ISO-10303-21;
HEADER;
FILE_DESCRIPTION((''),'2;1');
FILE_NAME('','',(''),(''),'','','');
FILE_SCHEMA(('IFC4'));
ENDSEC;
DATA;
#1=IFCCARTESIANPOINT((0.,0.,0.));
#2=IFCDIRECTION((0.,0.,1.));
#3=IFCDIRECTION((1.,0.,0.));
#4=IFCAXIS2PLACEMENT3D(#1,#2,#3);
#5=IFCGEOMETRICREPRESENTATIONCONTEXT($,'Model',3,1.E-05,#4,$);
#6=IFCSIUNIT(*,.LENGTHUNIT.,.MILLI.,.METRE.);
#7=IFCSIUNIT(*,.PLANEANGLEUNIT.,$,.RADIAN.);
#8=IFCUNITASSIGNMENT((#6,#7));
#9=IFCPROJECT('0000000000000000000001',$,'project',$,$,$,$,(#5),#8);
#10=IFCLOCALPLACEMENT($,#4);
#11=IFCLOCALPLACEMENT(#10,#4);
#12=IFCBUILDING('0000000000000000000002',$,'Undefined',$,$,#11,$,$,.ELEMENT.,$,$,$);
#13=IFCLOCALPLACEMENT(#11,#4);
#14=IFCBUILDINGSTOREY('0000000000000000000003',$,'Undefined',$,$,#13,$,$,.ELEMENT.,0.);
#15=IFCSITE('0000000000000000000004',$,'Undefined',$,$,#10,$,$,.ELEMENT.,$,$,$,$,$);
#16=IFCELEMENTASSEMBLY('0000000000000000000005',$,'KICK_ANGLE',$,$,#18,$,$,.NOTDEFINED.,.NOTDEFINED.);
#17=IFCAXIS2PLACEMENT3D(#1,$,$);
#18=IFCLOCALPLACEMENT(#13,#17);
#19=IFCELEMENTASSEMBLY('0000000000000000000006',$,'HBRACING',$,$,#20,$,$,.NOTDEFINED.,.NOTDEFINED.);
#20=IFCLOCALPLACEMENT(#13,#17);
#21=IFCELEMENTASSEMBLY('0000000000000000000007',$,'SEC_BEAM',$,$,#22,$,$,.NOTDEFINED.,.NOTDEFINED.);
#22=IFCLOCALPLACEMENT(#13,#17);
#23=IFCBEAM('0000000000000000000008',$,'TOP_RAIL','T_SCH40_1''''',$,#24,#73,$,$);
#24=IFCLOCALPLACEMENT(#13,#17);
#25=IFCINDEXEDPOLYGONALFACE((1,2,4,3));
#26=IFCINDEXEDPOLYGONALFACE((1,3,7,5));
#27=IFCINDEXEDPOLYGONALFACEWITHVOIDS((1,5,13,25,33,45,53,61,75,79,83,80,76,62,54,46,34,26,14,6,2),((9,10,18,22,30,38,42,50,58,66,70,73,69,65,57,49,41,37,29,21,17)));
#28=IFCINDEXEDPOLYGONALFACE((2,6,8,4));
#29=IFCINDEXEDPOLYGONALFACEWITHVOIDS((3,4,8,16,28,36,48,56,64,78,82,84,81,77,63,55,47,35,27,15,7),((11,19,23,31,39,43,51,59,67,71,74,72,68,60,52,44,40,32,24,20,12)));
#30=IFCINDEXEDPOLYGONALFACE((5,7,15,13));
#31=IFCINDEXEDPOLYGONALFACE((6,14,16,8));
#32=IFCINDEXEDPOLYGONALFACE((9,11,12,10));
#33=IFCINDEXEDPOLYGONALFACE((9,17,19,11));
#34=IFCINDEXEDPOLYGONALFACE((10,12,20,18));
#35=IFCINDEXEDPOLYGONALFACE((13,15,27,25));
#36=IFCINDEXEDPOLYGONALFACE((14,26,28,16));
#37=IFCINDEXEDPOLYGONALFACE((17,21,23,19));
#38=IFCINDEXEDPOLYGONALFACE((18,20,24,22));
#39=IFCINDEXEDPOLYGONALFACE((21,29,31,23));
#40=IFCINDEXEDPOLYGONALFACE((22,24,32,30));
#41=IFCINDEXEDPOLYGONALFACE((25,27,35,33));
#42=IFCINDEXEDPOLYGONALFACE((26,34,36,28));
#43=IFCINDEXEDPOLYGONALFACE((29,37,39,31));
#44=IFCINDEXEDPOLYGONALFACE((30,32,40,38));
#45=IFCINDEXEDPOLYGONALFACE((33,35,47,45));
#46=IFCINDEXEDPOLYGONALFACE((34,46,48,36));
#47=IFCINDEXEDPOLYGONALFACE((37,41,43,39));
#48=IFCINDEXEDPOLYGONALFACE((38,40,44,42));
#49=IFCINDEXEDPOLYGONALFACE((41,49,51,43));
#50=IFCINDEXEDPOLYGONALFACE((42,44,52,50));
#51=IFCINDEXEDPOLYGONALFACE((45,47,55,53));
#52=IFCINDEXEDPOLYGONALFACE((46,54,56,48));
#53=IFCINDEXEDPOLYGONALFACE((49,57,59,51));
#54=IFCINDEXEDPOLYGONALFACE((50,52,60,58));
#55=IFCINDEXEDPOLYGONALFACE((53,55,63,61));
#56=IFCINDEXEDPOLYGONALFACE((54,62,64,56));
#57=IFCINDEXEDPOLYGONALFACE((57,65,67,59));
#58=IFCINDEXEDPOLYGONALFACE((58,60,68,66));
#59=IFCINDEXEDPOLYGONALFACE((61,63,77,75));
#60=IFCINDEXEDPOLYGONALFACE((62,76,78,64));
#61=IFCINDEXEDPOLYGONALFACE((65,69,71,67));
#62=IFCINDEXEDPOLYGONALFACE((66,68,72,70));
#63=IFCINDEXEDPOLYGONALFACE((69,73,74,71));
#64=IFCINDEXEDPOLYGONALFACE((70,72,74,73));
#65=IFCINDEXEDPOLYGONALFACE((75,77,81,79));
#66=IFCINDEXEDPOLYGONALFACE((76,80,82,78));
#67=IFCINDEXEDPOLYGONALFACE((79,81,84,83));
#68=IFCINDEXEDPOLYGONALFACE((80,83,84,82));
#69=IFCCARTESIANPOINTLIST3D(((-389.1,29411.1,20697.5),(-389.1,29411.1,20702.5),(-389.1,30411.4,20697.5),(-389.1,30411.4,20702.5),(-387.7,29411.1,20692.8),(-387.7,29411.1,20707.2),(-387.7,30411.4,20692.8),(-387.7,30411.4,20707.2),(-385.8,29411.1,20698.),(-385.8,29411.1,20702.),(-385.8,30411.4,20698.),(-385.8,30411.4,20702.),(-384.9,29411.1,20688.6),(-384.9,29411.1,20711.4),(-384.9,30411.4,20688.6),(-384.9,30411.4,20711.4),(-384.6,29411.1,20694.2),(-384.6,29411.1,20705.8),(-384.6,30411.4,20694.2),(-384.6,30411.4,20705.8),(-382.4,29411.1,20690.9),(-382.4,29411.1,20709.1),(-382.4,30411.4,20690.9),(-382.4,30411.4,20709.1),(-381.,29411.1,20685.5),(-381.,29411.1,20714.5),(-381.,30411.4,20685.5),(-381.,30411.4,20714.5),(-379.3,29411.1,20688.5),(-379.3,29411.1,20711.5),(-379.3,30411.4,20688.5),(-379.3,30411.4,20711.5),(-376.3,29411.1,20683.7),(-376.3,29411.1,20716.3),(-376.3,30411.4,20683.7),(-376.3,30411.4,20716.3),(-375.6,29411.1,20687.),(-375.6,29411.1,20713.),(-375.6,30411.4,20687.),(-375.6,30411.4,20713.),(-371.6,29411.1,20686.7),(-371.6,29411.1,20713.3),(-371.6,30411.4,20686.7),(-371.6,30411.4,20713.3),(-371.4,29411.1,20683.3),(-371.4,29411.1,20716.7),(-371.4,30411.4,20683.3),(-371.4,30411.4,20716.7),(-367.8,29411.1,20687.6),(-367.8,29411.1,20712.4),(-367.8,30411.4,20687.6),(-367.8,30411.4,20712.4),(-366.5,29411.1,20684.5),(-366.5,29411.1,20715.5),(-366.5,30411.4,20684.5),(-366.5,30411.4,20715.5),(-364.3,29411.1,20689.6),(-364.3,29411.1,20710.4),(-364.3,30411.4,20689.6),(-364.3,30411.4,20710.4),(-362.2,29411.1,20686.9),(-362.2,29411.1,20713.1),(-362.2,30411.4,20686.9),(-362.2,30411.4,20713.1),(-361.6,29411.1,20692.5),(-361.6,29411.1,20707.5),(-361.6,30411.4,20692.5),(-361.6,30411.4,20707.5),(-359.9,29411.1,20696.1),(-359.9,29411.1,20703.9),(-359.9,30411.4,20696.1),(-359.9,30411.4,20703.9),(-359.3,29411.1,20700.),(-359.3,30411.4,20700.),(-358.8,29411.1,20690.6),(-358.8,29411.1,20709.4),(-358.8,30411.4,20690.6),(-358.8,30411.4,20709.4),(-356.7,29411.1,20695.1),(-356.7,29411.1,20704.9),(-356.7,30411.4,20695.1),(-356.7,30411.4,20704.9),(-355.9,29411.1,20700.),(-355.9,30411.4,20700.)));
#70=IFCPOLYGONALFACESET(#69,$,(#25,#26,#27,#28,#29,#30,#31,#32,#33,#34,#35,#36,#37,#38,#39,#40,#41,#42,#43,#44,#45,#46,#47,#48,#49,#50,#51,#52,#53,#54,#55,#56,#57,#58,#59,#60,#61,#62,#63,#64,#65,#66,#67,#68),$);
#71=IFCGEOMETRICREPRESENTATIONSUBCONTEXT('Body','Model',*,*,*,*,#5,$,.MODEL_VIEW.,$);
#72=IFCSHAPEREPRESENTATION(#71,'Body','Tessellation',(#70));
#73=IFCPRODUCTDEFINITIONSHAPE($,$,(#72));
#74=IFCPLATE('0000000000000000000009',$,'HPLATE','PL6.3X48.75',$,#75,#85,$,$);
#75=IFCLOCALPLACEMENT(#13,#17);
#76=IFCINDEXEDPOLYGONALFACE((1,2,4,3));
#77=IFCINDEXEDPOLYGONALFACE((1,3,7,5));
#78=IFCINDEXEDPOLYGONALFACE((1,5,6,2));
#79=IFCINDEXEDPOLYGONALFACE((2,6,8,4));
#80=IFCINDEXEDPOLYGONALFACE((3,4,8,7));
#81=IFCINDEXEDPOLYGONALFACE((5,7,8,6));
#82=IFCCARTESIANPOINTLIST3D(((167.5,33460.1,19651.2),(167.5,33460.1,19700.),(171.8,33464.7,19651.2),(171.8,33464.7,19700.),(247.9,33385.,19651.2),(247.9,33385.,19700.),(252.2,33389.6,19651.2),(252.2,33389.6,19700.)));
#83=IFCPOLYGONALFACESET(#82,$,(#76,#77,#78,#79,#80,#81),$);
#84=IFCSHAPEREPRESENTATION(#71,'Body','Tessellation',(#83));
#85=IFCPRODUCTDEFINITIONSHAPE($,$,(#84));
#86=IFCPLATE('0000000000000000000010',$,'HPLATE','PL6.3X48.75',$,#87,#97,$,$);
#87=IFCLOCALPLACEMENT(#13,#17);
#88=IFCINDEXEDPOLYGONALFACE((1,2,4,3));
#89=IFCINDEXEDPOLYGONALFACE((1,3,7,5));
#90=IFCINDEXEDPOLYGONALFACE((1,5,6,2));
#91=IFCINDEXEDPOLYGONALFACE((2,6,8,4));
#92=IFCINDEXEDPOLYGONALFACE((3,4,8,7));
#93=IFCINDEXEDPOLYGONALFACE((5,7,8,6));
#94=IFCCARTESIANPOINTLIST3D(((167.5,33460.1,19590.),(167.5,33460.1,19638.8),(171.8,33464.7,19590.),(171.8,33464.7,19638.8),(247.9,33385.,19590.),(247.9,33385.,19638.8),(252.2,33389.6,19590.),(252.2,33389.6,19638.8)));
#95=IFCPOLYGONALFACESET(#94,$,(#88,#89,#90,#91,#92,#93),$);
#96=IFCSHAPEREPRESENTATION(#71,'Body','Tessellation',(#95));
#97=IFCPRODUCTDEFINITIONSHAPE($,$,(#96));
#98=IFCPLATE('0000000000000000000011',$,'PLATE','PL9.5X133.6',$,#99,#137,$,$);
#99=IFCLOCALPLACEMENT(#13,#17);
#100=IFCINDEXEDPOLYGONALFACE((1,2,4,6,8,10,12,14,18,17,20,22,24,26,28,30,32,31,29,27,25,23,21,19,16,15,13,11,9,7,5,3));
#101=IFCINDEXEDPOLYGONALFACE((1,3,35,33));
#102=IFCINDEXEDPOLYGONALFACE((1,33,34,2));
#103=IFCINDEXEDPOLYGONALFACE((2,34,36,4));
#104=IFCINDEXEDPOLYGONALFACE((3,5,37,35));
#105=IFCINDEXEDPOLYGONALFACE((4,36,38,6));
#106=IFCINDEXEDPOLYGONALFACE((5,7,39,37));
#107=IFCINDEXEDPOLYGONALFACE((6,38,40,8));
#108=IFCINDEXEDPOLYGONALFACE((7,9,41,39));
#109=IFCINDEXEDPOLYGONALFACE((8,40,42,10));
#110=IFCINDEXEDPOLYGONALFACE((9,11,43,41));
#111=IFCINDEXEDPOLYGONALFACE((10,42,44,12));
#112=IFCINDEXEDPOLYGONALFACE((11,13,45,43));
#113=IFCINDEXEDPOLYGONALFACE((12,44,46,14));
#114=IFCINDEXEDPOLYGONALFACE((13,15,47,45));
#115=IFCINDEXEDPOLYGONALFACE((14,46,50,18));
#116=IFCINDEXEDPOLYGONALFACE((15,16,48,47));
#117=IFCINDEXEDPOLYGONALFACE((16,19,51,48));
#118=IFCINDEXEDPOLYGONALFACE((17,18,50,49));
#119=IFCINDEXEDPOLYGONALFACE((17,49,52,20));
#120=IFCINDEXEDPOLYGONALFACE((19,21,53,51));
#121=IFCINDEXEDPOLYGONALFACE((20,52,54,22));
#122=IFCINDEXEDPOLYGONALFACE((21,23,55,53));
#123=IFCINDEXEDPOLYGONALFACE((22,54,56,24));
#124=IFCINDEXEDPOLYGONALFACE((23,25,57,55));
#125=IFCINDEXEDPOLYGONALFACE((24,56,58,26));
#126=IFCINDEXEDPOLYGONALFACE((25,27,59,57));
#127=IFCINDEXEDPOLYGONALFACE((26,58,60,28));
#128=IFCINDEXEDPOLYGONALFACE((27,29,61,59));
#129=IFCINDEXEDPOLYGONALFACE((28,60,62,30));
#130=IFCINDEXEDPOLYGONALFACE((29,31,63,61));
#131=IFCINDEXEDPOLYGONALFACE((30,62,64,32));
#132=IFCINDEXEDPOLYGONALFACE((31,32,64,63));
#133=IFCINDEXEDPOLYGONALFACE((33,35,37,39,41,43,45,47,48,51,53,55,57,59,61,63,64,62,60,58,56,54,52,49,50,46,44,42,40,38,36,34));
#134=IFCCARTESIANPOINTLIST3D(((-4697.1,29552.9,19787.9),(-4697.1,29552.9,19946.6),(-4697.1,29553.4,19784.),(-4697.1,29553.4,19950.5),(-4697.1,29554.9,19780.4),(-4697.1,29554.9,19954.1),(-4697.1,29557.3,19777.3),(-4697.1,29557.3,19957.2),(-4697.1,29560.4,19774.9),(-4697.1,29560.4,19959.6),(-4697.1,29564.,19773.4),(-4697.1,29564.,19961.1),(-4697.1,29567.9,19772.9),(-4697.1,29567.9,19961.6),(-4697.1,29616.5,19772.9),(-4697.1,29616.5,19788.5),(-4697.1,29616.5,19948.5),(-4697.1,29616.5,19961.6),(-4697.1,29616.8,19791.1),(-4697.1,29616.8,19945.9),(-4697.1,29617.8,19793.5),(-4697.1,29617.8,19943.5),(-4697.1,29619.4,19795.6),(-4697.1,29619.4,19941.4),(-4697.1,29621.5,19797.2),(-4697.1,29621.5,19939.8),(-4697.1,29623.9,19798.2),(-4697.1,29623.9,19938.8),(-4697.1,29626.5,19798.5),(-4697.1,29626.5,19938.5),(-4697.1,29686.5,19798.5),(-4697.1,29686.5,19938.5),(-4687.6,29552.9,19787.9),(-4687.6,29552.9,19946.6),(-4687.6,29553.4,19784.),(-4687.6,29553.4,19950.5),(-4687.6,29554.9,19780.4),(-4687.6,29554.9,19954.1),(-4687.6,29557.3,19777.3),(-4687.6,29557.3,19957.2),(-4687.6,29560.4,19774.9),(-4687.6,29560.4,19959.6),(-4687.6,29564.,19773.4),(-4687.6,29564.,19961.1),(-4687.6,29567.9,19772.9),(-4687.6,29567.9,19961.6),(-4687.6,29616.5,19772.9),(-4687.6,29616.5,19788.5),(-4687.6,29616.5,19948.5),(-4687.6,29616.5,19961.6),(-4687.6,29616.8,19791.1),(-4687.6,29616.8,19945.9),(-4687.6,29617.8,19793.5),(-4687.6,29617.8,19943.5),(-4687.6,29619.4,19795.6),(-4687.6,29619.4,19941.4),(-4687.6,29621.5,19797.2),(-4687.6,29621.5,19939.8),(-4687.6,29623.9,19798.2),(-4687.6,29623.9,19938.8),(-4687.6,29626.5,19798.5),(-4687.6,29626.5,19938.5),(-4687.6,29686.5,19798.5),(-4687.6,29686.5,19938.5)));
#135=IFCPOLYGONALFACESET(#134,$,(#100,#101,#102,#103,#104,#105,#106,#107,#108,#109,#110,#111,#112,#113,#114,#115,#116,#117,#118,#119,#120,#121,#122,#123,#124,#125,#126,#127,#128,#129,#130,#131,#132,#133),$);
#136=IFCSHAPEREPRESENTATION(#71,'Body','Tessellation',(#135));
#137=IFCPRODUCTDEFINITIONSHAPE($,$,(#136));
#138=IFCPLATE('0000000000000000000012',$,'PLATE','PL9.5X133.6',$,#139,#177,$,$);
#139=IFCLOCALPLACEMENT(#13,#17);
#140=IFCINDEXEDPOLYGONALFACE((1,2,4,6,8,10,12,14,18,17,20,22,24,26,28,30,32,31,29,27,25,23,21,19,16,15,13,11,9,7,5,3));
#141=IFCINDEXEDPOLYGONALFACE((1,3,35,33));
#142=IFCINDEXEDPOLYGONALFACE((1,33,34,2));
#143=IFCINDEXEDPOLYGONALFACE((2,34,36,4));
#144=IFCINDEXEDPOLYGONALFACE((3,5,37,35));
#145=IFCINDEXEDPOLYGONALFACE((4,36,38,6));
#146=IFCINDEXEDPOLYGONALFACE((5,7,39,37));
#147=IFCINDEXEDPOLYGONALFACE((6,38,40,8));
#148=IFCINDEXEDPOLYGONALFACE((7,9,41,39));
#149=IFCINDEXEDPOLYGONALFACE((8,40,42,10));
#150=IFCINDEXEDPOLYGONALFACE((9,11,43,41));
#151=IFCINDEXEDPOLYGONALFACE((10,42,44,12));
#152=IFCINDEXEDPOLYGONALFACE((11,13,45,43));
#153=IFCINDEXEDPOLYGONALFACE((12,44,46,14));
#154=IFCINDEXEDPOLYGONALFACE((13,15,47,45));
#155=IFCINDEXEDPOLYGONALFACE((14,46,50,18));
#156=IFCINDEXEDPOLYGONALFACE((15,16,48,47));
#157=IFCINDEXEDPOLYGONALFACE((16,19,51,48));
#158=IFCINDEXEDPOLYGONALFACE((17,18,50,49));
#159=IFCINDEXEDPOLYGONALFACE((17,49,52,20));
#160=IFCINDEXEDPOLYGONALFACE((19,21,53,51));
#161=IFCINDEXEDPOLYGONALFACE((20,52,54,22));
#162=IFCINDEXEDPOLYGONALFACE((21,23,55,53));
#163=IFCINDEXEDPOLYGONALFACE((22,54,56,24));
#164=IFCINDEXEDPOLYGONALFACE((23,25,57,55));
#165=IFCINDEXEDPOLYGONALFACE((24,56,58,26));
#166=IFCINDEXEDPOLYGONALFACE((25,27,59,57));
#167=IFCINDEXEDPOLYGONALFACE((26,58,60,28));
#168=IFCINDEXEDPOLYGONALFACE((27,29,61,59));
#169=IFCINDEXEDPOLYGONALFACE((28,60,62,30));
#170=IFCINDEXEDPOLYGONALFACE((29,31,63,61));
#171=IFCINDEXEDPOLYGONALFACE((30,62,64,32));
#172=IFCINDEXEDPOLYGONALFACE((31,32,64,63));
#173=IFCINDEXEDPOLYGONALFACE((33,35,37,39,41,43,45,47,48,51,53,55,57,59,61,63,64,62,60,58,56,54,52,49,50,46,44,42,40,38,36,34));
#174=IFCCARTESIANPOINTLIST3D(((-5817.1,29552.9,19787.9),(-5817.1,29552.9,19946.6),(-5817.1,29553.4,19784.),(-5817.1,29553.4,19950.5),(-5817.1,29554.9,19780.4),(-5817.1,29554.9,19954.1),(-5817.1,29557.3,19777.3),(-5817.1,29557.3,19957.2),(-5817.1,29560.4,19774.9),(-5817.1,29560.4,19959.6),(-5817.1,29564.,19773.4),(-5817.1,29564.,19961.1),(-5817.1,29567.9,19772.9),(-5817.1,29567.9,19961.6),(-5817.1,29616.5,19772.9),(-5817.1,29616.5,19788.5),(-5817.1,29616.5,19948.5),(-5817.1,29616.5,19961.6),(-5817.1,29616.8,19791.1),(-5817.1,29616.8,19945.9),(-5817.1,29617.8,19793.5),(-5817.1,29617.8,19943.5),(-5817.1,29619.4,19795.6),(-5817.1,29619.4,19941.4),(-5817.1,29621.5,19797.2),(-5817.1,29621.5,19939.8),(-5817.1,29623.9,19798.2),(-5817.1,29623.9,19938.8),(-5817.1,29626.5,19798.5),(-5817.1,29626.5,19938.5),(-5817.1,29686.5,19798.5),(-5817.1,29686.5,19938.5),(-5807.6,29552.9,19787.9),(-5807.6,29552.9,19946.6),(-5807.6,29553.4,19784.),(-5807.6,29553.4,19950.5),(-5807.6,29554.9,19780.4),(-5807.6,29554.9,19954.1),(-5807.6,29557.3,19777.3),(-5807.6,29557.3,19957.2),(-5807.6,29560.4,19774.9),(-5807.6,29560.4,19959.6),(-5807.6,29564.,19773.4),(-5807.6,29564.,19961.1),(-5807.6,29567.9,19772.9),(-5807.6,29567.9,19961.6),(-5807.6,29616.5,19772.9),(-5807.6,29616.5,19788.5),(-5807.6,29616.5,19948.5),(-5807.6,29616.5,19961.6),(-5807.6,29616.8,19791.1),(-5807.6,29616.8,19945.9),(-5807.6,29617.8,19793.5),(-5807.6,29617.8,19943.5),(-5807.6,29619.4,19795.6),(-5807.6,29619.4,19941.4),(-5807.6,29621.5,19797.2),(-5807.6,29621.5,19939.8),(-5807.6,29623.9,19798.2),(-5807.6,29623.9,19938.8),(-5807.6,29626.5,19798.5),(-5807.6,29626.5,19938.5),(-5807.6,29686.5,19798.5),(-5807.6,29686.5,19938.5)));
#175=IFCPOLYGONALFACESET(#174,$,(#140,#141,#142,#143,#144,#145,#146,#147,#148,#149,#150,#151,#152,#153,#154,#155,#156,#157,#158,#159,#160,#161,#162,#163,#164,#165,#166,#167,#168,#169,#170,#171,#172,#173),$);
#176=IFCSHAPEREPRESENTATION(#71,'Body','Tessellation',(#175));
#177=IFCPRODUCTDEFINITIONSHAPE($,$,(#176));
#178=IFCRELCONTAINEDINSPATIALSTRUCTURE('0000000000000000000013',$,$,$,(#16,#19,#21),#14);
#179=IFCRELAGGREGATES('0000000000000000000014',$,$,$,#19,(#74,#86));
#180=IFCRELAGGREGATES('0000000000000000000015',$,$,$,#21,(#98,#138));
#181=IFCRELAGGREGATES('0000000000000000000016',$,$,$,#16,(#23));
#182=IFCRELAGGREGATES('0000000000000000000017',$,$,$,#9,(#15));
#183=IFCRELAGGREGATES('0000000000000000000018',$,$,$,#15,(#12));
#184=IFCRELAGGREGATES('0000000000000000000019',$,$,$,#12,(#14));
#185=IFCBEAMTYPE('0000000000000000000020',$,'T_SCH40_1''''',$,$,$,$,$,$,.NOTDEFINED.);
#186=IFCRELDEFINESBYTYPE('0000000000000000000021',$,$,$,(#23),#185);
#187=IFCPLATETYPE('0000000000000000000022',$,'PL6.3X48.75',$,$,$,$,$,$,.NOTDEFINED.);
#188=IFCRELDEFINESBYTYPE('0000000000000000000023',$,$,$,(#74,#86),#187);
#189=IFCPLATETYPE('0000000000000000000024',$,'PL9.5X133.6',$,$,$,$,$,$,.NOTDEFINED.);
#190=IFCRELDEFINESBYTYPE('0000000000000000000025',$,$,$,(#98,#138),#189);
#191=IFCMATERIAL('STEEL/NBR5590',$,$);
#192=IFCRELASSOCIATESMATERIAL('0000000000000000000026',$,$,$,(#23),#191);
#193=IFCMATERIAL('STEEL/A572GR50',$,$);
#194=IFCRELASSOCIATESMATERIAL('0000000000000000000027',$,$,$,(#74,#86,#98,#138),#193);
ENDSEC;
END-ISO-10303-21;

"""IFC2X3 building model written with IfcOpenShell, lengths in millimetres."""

from ifc_helpers import new_model, si_unit, frame, frame_2d, origin_with_axes, origin_2d_with_axis, place, context, subcontext, project, spatial, polyline, circle_curve, parameter, trimmed, segment, composite_curve, hollow_circle, outline, extrude, material, type_object, element, aggregate, save


model = new_model("IFC2X3")

# Units and contexts
model_context = context("Model", 3, precision=1e-05, world=origin_with_axes())
body_context = subcontext(model_context, "Body", "Model", "MODEL_VIEW")
ifc_project = project(units=[si_unit("LENGTHUNIT", "METRE", prefix="MILLI"), si_unit("PLANEANGLEUNIT", "RADIAN")], contexts=[model_context])

# Site, building, storey
site_placement = place(None, origin_with_axes())
site = spatial("IfcSite", under=ifc_project, at=site_placement, Name="Undefined", CompositionType="ELEMENT")
building_placement = place(site_placement, origin_with_axes())
building = spatial("IfcBuilding", under=site, at=building_placement, Name="Undefined", CompositionType="ELEMENT")
storey_placement = place(building_placement, origin_with_axes())
storey = spatial("IfcBuildingStorey", under=building, at=storey_placement, Name="Undefined", CompositionType="ELEMENT", Elevation=0.0)

# Shared definitions
ifc_material_1 = material(Name="STEEL/NBR5590")

# Element assembly
assembly_1_placement = place(storey_placement, origin_with_axes())
assembly_1 = element("IfcElementAssembly", 1, at=assembly_1_placement, inside=storey, Name="KICK_ANGLE", AssemblyPlace="NOTDEFINED", PredefinedType="NOTDEFINED")

# Element assemblies
assembly_2_placement = place(storey_placement, origin_with_axes())
assembly_2 = element("IfcElementAssembly", 2, at=assembly_2_placement, inside=storey, Name="HBRACING", AssemblyPlace="NOTDEFINED", PredefinedType="NOTDEFINED")
ifc_material_2 = material(Name="STEEL/A572GR50")
assembly_3_placement = place(storey_placement, origin_with_axes())
assembly_3 = element("IfcElementAssembly", 3, at=assembly_3_placement, inside=storey, Name="SEC_BEAM", AssemblyPlace="NOTDEFINED", PredefinedType="NOTDEFINED")

# Beam
beam_type_1 = type_object("IfcBeamType", Name="T_SCH40_1''", PredefinedType="NOTDEFINED")
beam_1_placement = place(assembly_1_placement, frame((-372.6, 29411.1, 20700.0), z_axis=(0.0, 0.0, 1.0), x_axis=(0.0, 1.0, 0.0)))
beam_1 = element("IfcBeam", 4, at=beam_1_placement, type_object=beam_type_1, material=ifc_material_1, Name="TOP_RAIL", Description="T_SCH40_1''", context=body_context, shape_type="SweptSolid", body=[
    extrude(hollow_circle(Radius=16.7, WallThickness=3.4, at=origin_2d_with_axis()), frame((1000.3, 0.0, 0.0), z_axis=(-1.0, 0.0, 0.0), x_axis=(0.0, -1.0, 0.0)), (0.0, 0.0, 1.0), 1000.3),
])

# Plates
plate_type_1 = type_object("IfcPlateType", Name="PL6.3X48.75", PredefinedType="NOTDEFINED")
plate_1_placement = place(assembly_2_placement, frame((250.1, 33387.3, 19700.0), z_axis=(0.682318, 0.731055, 0.0), x_axis=(0.0, 0.0, -1.0)))
plate_1 = element("IfcPlate", 5, at=plate_1_placement, type_object=plate_type_1, material=ifc_material_2, Name="HPLATE", Description="PL6.3X48.75", context=body_context, shape_type="SweptSolid", body=[
    extrude(outline(polyline([(0.0, 0.0), (48.8, 0.0), (48.8, 110.0), (0.0, 110.0), (0.0, 0.0)])), frame((0.0, 0.0, -3.1), z_axis=(0.0, 0.0, 1.0), x_axis=(1.0, 0.0, 0.0)), (0.0, 0.0, 1.0), 6.3),
])
plate_2_placement = place(assembly_2_placement, frame((250.1, 33387.3, 19638.8), z_axis=(0.682318, 0.731055, 0.0), x_axis=(0.0, 0.0, -1.0)))
plate_2 = element("IfcPlate", 6, at=plate_2_placement, type_object=plate_type_1, material=ifc_material_2, Name="HPLATE", Description="PL6.3X48.75", context=body_context, shape_type="SweptSolid", body=[
    extrude(outline(polyline([(0.0, 0.0), (48.8, 0.0), (48.8, 110.0), (0.0, 110.0), (0.0, 0.0)])), frame((0.0, 0.0, -3.1), z_axis=(0.0, 0.0, 1.0), x_axis=(1.0, 0.0, 0.0)), (0.0, 0.0, 1.0), 6.3),
])
plate_type_2 = type_object("IfcPlateType", Name="PL9.5X133.6", PredefinedType="NOTDEFINED")
plate_3_placement = place(assembly_3_placement, frame((-4692.3, 29552.9, 19961.6), z_axis=(1.0, 0.0, 0.0), x_axis=(0.0, 0.0, -1.0)))
plate_3 = element("IfcPlate", 7, at=plate_3_placement, type_object=plate_type_2, material=ifc_material_2, Name="PLATE", Description="PL9.5X133.6", context=body_context, shape_type="SweptSolid", body=[
    extrude(outline(composite_curve([segment(trimmed(circle_curve(frame_2d((15.0, 15.0), x_axis=(-1.0, 0.0)), 15.0), [parameter(0.0)], [parameter(1.570796)], True, "PARAMETER"), True, "CONTINUOUS"), segment(polyline([(15.0, 0.0), (173.7, 0.0)]), True, "CONTINUOUS"), segment(trimmed(circle_curve(frame_2d((173.7, 15.0), x_axis=(0.0, -1.0)), 15.0), [parameter(0.0)], [parameter(1.570796)], True, "PARAMETER"), True, "CONTINUOUS"), segment(polyline([(188.7, 15.0), (188.7, 63.6), (173.1, 63.6)]), True, "CONTINUOUS"), segment(trimmed(circle_curve(frame_2d((173.1, 73.6), x_axis=(0.0, -1.0)), 10.0), [parameter(0.0)], [parameter(4.712389)], False, "PARAMETER"), True, "CONTINUOUS"), segment(polyline([(163.1, 73.6), (163.1, 133.6), (23.1, 133.6), (23.1, 73.6)]), True, "CONTINUOUS"), segment(trimmed(circle_curve(frame_2d((13.1, 73.6), x_axis=(1.0, 0.0)), 10.0), [parameter(0.0)], [parameter(4.712389)], False, "PARAMETER"), True, "CONTINUOUS"), segment(polyline([(13.1, 63.6), (0.0, 63.6), (0.0, 15.0)]), True, "CONTINUOUS")], self_intersect=True)), frame((0.0, 0.0, -4.8), z_axis=(0.0, 0.0, 1.0), x_axis=(1.0, 0.0, 0.0)), (0.0, 0.0, 1.0), 9.5),
])
plate_4_placement = place(assembly_3_placement, frame((-5812.3, 29552.9, 19961.6), z_axis=(1.0, 0.0, 0.0), x_axis=(0.0, 0.0, -1.0)))
plate_4 = element("IfcPlate", 8, at=plate_4_placement, type_object=plate_type_2, material=ifc_material_2, Name="PLATE", Description="PL9.5X133.6", context=body_context, shape_type="SweptSolid", body=[
    extrude(outline(composite_curve([segment(trimmed(circle_curve(frame_2d((15.0, 15.0), x_axis=(-1.0, 0.0)), 15.0), [parameter(0.0)], [parameter(1.570796)], True, "PARAMETER"), True, "CONTINUOUS"), segment(polyline([(15.0, 0.0), (173.7, 0.0)]), True, "CONTINUOUS"), segment(trimmed(circle_curve(frame_2d((173.7, 15.0), x_axis=(0.0, -1.0)), 15.0), [parameter(0.0)], [parameter(1.570796)], True, "PARAMETER"), True, "CONTINUOUS"), segment(polyline([(188.7, 15.0), (188.7, 63.6), (173.1, 63.6)]), True, "CONTINUOUS"), segment(trimmed(circle_curve(frame_2d((173.1, 73.6), x_axis=(0.0, -1.0)), 10.0), [parameter(0.0)], [parameter(4.712389)], False, "PARAMETER"), True, "CONTINUOUS"), segment(polyline([(163.1, 73.6), (163.1, 133.6), (23.1, 133.6), (23.1, 73.6)]), True, "CONTINUOUS"), segment(trimmed(circle_curve(frame_2d((13.1, 73.6), x_axis=(1.0, 0.0)), 10.0), [parameter(0.0)], [parameter(4.712389)], False, "PARAMETER"), True, "CONTINUOUS"), segment(polyline([(13.1, 63.6), (0.0, 63.6), (0.0, 15.0)]), True, "CONTINUOUS")], self_intersect=True)), frame((0.0, 0.0, -4.8), z_axis=(0.0, 0.0, 1.0), x_axis=(1.0, 0.0, 0.0)), (0.0, 0.0, 1.0), 9.5),
])

aggregate(assembly_2, [plate_1, plate_2])

aggregate(assembly_3, [plate_3, plate_4])
aggregate(assembly_1, [beam_1])

save(model, "model.ifc")
